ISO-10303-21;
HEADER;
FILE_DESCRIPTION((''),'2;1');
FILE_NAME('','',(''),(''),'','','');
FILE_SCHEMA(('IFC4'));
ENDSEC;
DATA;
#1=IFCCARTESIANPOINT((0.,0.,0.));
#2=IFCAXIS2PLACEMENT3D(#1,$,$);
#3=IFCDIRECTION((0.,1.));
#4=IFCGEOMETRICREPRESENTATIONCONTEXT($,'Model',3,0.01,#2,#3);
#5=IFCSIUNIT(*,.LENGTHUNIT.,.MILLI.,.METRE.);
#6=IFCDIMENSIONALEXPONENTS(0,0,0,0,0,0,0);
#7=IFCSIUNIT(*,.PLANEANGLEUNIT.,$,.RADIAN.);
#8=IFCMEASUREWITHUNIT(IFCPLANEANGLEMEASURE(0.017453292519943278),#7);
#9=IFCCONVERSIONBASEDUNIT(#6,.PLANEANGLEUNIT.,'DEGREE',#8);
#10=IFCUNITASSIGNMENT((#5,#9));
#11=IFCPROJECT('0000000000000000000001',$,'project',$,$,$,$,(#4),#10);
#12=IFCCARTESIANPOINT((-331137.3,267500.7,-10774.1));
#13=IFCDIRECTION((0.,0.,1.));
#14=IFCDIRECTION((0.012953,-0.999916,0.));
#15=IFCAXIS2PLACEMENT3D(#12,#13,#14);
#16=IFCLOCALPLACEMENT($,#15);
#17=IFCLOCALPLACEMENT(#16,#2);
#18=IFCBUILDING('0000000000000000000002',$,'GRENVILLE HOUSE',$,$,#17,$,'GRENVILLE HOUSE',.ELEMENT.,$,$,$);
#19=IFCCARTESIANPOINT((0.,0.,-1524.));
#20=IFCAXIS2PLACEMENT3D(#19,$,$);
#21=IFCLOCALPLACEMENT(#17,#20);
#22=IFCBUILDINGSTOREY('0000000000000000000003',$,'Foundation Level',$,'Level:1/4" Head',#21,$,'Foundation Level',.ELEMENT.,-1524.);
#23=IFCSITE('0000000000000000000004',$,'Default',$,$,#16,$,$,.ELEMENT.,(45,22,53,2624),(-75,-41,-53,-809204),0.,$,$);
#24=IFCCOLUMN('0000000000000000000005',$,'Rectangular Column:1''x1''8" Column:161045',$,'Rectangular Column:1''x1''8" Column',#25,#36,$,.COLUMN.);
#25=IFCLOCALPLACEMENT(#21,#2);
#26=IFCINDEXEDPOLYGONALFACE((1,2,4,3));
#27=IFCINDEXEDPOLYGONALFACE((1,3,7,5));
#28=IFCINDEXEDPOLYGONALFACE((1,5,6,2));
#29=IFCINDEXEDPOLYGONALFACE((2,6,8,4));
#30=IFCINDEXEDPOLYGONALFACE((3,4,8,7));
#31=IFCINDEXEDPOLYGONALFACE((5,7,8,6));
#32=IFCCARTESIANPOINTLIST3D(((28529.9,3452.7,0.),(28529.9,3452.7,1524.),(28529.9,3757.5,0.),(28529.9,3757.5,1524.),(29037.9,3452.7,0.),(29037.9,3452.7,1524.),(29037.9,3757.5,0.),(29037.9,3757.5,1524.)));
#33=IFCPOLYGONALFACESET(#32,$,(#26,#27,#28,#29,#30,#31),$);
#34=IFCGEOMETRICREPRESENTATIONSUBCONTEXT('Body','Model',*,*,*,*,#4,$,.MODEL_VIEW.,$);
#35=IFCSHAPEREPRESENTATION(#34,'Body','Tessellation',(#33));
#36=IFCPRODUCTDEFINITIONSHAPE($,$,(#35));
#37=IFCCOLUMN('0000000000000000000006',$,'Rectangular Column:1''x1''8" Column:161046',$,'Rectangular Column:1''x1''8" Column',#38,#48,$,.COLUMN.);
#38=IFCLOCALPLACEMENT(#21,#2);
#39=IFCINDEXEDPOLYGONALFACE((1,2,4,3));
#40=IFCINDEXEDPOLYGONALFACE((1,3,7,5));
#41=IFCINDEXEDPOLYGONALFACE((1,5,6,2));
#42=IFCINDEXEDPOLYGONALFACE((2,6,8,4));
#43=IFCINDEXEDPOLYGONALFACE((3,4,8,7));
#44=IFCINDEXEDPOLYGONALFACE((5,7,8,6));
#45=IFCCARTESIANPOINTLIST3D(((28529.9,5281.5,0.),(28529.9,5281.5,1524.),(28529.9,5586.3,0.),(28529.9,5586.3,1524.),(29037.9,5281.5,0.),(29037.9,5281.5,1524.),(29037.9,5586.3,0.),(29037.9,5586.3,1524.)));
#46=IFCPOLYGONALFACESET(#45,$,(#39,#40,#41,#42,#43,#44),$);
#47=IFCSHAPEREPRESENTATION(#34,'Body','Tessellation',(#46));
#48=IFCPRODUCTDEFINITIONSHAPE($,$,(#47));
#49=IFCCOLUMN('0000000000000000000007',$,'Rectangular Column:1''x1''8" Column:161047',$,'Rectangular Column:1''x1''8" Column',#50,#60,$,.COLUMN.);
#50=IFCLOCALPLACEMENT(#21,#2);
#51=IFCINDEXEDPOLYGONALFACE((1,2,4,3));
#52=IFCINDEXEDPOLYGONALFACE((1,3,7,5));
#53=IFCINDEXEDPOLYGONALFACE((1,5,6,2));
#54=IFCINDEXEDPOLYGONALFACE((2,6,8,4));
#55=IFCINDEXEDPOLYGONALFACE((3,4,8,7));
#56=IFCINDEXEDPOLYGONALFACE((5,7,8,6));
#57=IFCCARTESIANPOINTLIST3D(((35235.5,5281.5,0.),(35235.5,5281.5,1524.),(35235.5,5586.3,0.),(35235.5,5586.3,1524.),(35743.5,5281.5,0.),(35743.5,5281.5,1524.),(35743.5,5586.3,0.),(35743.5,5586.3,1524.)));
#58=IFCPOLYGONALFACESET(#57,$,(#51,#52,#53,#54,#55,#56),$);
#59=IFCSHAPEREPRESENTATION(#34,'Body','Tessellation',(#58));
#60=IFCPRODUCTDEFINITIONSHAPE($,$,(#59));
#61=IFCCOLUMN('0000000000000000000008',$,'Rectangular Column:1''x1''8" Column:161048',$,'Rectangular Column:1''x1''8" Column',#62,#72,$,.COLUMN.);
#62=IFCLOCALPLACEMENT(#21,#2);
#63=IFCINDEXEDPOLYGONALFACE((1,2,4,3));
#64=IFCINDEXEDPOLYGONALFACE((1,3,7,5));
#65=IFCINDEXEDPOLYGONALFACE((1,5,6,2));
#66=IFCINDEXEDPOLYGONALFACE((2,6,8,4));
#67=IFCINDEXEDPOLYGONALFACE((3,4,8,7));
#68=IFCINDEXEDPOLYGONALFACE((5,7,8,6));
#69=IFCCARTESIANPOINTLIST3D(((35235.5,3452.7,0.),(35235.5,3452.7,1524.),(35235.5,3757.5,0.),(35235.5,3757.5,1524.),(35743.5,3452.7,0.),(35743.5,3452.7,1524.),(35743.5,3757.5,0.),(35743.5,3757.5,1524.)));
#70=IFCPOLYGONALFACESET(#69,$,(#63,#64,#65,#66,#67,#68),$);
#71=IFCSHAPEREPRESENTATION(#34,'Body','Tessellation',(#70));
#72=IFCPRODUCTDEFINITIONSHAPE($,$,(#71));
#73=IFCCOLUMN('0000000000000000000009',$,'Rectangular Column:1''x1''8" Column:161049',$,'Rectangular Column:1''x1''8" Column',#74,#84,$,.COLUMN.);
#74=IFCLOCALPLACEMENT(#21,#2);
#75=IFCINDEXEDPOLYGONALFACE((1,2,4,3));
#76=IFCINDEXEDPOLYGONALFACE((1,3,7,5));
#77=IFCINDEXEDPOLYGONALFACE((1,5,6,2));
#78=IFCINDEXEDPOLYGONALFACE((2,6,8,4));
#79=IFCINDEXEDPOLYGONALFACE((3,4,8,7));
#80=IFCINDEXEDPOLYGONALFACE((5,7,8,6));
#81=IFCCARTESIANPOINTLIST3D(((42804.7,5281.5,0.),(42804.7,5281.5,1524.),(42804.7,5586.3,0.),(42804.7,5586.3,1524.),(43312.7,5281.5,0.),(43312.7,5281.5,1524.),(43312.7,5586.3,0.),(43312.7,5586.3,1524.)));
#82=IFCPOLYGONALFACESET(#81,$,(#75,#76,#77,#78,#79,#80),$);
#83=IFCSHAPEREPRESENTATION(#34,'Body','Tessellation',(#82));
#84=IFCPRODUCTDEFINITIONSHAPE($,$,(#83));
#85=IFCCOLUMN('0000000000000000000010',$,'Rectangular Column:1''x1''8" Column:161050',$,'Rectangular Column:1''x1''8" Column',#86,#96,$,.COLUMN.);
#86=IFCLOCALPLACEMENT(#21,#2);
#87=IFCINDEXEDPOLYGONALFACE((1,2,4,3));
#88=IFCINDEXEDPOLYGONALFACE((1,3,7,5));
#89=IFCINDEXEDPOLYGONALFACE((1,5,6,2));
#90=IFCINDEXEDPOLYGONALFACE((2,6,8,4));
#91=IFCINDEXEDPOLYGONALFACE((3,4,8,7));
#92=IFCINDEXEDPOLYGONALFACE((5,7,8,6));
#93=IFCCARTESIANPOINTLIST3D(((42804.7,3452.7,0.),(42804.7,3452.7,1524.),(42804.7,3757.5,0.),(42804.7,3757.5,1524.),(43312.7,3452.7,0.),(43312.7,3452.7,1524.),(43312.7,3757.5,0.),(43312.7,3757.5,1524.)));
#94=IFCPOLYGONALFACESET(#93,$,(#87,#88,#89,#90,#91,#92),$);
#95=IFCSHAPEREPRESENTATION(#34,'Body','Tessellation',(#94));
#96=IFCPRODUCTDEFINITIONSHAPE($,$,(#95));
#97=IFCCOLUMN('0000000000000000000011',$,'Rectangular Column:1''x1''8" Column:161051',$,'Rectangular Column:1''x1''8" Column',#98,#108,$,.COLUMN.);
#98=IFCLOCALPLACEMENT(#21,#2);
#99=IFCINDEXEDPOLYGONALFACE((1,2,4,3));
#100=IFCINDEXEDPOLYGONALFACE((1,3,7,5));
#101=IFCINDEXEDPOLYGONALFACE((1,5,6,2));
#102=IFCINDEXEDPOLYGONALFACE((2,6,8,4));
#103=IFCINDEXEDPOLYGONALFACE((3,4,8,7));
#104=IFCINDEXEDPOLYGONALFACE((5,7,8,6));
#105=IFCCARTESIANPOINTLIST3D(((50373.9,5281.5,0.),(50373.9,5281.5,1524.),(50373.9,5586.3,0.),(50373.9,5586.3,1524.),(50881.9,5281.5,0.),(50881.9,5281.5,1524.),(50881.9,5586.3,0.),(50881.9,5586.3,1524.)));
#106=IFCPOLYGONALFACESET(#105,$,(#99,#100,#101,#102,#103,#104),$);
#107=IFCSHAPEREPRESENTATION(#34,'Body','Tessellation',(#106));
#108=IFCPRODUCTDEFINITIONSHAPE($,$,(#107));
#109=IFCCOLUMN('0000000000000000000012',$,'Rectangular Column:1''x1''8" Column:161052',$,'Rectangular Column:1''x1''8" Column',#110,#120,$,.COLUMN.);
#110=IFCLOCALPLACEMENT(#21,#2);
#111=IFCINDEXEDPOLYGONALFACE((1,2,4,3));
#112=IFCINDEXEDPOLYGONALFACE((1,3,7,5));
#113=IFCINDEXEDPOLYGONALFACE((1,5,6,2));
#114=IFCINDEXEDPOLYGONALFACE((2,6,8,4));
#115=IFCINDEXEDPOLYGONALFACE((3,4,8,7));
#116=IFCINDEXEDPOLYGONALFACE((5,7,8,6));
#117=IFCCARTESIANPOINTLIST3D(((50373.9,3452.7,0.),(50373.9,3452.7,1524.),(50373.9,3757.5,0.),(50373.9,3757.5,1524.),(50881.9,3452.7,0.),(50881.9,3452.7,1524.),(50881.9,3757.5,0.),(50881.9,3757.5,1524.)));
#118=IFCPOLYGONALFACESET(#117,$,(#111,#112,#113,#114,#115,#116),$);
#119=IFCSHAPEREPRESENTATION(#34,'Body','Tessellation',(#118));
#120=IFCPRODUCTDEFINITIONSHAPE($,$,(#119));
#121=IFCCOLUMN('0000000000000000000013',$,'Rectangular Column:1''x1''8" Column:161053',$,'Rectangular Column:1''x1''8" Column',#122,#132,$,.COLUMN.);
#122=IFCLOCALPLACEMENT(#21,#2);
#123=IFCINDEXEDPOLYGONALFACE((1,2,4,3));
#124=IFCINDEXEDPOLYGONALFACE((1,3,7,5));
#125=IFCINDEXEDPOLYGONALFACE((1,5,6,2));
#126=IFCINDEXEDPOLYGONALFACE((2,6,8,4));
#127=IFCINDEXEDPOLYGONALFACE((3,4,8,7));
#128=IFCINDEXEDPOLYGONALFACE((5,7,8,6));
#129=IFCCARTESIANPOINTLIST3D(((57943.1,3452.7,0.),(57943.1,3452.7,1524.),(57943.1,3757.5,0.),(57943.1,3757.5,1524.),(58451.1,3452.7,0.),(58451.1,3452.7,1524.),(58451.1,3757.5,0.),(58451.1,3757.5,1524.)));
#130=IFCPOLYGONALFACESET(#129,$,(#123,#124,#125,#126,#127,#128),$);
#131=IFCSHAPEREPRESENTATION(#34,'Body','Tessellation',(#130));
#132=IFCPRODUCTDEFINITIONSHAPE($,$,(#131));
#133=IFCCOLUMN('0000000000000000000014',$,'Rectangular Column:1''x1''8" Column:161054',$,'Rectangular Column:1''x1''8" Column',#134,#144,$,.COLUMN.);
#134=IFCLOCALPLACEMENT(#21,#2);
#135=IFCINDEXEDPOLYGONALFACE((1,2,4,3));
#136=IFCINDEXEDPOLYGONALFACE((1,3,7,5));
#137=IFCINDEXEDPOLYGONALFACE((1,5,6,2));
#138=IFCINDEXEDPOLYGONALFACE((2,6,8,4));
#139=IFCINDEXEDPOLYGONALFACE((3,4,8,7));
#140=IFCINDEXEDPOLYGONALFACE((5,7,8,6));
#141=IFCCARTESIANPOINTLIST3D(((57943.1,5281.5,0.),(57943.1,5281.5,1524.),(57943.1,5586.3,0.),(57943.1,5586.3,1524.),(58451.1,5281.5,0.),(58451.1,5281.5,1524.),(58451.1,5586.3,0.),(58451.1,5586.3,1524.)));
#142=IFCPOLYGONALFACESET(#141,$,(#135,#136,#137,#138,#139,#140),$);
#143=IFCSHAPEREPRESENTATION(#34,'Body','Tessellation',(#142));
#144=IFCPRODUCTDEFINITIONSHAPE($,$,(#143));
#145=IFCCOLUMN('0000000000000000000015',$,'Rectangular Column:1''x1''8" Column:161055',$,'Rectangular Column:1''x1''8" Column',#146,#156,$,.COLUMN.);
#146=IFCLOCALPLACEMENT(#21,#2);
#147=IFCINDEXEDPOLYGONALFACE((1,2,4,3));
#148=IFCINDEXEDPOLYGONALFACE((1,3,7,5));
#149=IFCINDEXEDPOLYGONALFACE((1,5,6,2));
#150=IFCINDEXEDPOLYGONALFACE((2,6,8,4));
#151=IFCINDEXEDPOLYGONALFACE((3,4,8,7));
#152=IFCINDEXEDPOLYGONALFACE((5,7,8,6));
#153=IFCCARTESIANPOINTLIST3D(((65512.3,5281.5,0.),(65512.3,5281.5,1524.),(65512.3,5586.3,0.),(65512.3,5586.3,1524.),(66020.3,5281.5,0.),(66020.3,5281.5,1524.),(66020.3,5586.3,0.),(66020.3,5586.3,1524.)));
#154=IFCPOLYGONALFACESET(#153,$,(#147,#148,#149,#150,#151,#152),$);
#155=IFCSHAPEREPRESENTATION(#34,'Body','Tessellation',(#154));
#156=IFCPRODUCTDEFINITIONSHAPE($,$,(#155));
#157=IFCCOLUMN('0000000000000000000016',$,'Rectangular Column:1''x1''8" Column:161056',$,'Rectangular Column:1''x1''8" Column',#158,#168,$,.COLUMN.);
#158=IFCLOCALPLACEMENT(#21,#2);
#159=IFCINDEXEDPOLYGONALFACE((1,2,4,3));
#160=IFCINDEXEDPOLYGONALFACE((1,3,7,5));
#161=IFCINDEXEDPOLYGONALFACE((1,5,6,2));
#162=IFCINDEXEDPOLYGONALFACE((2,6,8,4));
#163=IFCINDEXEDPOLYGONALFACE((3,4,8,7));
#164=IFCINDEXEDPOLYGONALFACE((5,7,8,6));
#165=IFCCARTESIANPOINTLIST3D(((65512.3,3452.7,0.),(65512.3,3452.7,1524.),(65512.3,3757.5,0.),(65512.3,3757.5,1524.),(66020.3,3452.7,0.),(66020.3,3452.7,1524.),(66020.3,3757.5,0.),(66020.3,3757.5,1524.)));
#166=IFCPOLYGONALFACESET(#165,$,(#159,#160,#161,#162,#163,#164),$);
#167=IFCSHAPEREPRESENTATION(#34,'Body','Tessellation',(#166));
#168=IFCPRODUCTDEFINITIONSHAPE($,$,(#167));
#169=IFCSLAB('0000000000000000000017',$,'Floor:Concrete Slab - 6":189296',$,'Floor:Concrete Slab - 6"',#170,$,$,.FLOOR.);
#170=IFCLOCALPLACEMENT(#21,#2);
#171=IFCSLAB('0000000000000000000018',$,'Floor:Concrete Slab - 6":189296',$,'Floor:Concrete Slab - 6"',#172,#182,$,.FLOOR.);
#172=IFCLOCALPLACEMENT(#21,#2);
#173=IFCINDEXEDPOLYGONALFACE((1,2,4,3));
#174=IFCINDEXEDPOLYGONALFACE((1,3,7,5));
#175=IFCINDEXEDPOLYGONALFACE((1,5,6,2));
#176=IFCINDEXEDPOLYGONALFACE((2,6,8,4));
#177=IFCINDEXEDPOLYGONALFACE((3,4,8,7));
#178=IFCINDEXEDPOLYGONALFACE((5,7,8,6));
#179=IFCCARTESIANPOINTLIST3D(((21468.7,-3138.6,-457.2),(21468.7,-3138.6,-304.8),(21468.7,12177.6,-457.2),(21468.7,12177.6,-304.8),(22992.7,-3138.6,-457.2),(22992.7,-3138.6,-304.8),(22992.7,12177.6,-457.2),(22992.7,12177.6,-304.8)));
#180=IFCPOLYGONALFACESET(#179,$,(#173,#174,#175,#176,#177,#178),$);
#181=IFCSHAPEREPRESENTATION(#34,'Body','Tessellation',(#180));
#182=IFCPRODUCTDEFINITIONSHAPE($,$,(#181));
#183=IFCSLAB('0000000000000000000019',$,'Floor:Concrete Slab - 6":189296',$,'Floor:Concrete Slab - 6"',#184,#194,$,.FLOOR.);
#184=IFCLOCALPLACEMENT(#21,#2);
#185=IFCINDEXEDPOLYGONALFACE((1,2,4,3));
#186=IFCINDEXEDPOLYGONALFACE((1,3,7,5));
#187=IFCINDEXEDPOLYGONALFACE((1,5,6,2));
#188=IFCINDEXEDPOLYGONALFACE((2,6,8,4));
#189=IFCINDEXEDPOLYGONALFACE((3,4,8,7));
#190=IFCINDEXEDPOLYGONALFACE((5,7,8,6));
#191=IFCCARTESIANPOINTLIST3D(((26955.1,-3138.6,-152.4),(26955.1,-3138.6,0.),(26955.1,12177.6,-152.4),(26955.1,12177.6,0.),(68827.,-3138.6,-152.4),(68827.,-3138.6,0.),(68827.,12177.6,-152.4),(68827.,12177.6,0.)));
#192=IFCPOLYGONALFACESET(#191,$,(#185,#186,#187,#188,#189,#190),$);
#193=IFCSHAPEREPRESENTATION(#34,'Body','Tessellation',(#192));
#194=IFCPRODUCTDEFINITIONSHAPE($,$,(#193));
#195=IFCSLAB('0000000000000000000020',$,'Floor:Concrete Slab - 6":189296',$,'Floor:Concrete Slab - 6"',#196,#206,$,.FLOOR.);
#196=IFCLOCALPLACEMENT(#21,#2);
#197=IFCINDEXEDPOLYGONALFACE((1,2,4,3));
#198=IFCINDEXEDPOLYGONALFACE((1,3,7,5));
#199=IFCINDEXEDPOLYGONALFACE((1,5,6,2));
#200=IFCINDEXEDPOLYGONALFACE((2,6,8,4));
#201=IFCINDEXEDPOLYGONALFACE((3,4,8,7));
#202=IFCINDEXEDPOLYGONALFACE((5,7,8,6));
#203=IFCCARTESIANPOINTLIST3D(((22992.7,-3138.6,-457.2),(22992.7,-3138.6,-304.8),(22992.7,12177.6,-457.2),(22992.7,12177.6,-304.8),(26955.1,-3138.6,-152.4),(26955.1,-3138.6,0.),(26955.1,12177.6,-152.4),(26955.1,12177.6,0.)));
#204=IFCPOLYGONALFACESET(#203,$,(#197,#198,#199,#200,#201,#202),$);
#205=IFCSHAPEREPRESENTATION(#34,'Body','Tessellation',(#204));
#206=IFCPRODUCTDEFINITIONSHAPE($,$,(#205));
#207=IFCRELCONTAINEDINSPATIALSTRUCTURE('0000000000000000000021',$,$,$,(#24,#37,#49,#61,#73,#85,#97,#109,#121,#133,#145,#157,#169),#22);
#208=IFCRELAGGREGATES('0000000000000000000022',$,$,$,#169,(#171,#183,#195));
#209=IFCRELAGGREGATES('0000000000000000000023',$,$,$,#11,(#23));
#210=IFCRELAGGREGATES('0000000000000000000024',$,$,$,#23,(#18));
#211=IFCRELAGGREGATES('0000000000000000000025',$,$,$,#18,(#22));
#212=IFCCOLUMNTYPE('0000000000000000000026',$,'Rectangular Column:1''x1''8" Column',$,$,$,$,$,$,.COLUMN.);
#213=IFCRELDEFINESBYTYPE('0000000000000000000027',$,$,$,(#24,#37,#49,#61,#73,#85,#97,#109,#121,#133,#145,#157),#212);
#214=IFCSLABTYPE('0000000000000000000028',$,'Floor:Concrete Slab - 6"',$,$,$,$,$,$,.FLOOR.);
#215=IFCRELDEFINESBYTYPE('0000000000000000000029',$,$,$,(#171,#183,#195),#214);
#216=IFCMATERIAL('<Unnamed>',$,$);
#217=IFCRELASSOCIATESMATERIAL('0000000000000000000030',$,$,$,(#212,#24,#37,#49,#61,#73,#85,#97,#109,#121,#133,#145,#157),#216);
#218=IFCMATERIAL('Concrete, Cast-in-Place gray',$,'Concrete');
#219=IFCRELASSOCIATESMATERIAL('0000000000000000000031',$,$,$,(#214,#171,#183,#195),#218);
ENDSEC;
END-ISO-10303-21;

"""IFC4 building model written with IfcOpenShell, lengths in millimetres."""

from ifc_helpers import new_model, entity, si_unit, converted_unit, direction, frame, origin, place, context, subcontext, project, spatial, indexed_curve, outline, extrude, source, transform, mapped, material, type_object, type_shapes, element, aggregate, save


model = new_model("IFC4")

# Units and contexts
model_context = context("Model", 3, precision=0.01, world=origin(), true_north=direction((0.0, 1.0)))
body_context = subcontext(model_context, "Body", "Model", "MODEL_VIEW")
ifc_project = project(units=[si_unit("LENGTHUNIT", "METRE", prefix="MILLI"), converted_unit("PLANEANGLEUNIT", "DEGREE", entity("IfcPlaneAngleMeasure", 0.017453292519943278), si_unit("PLANEANGLEUNIT", "RADIAN"), dimensions=[0, 0, 0, 0, 0, 0, 0])], contexts=[model_context])

# Site, building, storey
site_placement = place(None, frame((-331137.3, 267500.7, -10774.1), z_axis=(0.0, 0.0, 1.0), x_axis=(0.012953, -0.999916, 0.0)))
site = spatial("IfcSite", under=ifc_project, at=site_placement, Name="Default", CompositionType="ELEMENT", RefLatitude=(45, 22, 53, 2624), RefLongitude=(-75, -41, -53, -809204), RefElevation=0.0)
building_placement = place(site_placement, origin())
building = spatial("IfcBuilding", under=site, at=building_placement, Name="GRENVILLE HOUSE", LongName="GRENVILLE HOUSE", CompositionType="ELEMENT")
storey_placement = place(building_placement, frame((0.0, 0.0, -1524.0)))
storey = spatial("IfcBuildingStorey", under=building, at=storey_placement, Name="Foundation Level", ObjectType="Level:1/4\" Head", LongName="Foundation Level", CompositionType="ELEMENT", Elevation=-1524.0)

# Columns
ifc_material_1 = material(Name="<Unnamed>")
column_type = type_object("IfcColumnType", Name="Rectangular Column:1'x1'8\" Column", PredefinedType="COLUMN", material=ifc_material_1)
shared_shape = source(origin(), body_context, "Body", "SweptSolid", [
    extrude(outline(indexed_curve([(-254.0, -152.4), (254.0, -152.4), (254.0, 152.4), (-254.0, 152.4), (-254.0, -152.4)], self_intersect=False)), frame((0.0, 0.0, -1524.0), z_axis=(0.0, 0.0, 1.0), x_axis=(-1.0, 0.0, 0.0)), (0.0, 0.0, 1.0), 1524.0),
])
type_shapes(column_type, [shared_shape])
for number, where, name in (
    (1, (28783.9, 3605.1, 1524.0), "Rectangular Column:1'x1'8\" Column:161045"),
    (2, (28783.9, 5433.9, 1524.0), "Rectangular Column:1'x1'8\" Column:161046"),
    (3, (35489.5, 5433.9, 1524.0), "Rectangular Column:1'x1'8\" Column:161047"),
    (4, (35489.5, 3605.1, 1524.0), "Rectangular Column:1'x1'8\" Column:161048"),
    (5, (43058.7, 5433.9, 1524.0), "Rectangular Column:1'x1'8\" Column:161049"),
    (6, (43058.7, 3605.1, 1524.0), "Rectangular Column:1'x1'8\" Column:161050"),
    (7, (50627.9, 5433.9, 1524.0), "Rectangular Column:1'x1'8\" Column:161051"),
    (8, (50627.9, 3605.1, 1524.0), "Rectangular Column:1'x1'8\" Column:161052"),
    (9, (58197.1, 3605.1, 1524.0), "Rectangular Column:1'x1'8\" Column:161053"),
    (10, (58197.1, 5433.9, 1524.0), "Rectangular Column:1'x1'8\" Column:161054"),
    (11, (65766.3, 5433.9, 1524.0), "Rectangular Column:1'x1'8\" Column:161055"),
    (12, (65766.3, 3605.1, 1524.0), "Rectangular Column:1'x1'8\" Column:161056"),
):
    element("IfcColumn", number, at=place(storey_placement, frame(where)), inside=storey, type_object=column_type, material=ifc_material_1, Name=name, ObjectType="Rectangular Column:1'x1'8\" Column", PredefinedType="COLUMN", context=body_context, shape_type="MappedRepresentation", body=[
        mapped(shared_shape, transform((0.0, 0.0, 0.0), scale=1.0)),
    ])

# Slabs
slab_1_placement = place(storey_placement, frame((21468.7, -3138.6, -457.2)))
slab_1 = element("IfcSlab", 13, at=slab_1_placement, inside=storey, Name="Floor:Concrete Slab - 6\":189296", ObjectType="Floor:Concrete Slab - 6\"", PredefinedType="FLOOR")
ifc_material_2 = material(Name="Concrete, Cast-in-Place gray", Category="Concrete")
slab_type = type_object("IfcSlabType", Name="Floor:Concrete Slab - 6\"", PredefinedType="FLOOR", material=ifc_material_2)
slab_2_placement = place(slab_1_placement, origin())
slab_2 = element("IfcSlab", 14, at=slab_2_placement, type_object=slab_type, material=ifc_material_2, Name="Floor:Concrete Slab - 6\":189296", ObjectType="Floor:Concrete Slab - 6\"", PredefinedType="FLOOR", context=body_context, shape_type="SweptSolid", body=[
    extrude(outline(indexed_curve([(-762.0, 7658.1), (-762.0, -7658.1), (762.0, -7658.1), (762.0, 7658.1), (-762.0, 7658.1)], self_intersect=False)), frame((762.0, 7658.1, 152.4)), (0.0, 0.0, -1.0), 152.4),
])
slab_3_placement = place(slab_1_placement, origin())
slab_3 = element("IfcSlab", 15, at=slab_3_placement, type_object=slab_type, material=ifc_material_2, Name="Floor:Concrete Slab - 6\":189296", ObjectType="Floor:Concrete Slab - 6\"", PredefinedType="FLOOR", context=body_context, shape_type="SweptSolid", body=[
    extrude(outline(indexed_curve([(20935.9, -7658.1), (20936.0, 7658.1), (-20935.9, 7658.1), (-20936.0, -7658.1), (20935.9, -7658.1)], self_intersect=False)), frame((26422.4, 7658.1, 457.2)), (0.0, 0.0, -1.0), 152.4),
])
slab_4_placement = place(slab_1_placement, origin())
slab_4 = element("IfcSlab", 16, at=slab_4_placement, type_object=slab_type, material=ifc_material_2, Name="Floor:Concrete Slab - 6\":189296", ObjectType="Floor:Concrete Slab - 6\"", PredefinedType="FLOOR", context=body_context, shape_type="SweptSolid", body=[
    extrude(outline(indexed_curve([(-1987.1, -7658.1), (1987.1, -7658.1), (1987.1, 7658.1), (-1987.1, 7658.1), (-1987.1, -7658.1)], self_intersect=False)), frame((3505.2, 7658.1, 304.8), z_axis=(-0.076697, 0.0, 0.997054), x_axis=(0.997054, 0.0, 0.076697)), (-0.076697, 0.0, -0.997054), 152.4),
])
aggregate(slab_1, [slab_2, slab_3, slab_4])

save(model, "model.ifc")
